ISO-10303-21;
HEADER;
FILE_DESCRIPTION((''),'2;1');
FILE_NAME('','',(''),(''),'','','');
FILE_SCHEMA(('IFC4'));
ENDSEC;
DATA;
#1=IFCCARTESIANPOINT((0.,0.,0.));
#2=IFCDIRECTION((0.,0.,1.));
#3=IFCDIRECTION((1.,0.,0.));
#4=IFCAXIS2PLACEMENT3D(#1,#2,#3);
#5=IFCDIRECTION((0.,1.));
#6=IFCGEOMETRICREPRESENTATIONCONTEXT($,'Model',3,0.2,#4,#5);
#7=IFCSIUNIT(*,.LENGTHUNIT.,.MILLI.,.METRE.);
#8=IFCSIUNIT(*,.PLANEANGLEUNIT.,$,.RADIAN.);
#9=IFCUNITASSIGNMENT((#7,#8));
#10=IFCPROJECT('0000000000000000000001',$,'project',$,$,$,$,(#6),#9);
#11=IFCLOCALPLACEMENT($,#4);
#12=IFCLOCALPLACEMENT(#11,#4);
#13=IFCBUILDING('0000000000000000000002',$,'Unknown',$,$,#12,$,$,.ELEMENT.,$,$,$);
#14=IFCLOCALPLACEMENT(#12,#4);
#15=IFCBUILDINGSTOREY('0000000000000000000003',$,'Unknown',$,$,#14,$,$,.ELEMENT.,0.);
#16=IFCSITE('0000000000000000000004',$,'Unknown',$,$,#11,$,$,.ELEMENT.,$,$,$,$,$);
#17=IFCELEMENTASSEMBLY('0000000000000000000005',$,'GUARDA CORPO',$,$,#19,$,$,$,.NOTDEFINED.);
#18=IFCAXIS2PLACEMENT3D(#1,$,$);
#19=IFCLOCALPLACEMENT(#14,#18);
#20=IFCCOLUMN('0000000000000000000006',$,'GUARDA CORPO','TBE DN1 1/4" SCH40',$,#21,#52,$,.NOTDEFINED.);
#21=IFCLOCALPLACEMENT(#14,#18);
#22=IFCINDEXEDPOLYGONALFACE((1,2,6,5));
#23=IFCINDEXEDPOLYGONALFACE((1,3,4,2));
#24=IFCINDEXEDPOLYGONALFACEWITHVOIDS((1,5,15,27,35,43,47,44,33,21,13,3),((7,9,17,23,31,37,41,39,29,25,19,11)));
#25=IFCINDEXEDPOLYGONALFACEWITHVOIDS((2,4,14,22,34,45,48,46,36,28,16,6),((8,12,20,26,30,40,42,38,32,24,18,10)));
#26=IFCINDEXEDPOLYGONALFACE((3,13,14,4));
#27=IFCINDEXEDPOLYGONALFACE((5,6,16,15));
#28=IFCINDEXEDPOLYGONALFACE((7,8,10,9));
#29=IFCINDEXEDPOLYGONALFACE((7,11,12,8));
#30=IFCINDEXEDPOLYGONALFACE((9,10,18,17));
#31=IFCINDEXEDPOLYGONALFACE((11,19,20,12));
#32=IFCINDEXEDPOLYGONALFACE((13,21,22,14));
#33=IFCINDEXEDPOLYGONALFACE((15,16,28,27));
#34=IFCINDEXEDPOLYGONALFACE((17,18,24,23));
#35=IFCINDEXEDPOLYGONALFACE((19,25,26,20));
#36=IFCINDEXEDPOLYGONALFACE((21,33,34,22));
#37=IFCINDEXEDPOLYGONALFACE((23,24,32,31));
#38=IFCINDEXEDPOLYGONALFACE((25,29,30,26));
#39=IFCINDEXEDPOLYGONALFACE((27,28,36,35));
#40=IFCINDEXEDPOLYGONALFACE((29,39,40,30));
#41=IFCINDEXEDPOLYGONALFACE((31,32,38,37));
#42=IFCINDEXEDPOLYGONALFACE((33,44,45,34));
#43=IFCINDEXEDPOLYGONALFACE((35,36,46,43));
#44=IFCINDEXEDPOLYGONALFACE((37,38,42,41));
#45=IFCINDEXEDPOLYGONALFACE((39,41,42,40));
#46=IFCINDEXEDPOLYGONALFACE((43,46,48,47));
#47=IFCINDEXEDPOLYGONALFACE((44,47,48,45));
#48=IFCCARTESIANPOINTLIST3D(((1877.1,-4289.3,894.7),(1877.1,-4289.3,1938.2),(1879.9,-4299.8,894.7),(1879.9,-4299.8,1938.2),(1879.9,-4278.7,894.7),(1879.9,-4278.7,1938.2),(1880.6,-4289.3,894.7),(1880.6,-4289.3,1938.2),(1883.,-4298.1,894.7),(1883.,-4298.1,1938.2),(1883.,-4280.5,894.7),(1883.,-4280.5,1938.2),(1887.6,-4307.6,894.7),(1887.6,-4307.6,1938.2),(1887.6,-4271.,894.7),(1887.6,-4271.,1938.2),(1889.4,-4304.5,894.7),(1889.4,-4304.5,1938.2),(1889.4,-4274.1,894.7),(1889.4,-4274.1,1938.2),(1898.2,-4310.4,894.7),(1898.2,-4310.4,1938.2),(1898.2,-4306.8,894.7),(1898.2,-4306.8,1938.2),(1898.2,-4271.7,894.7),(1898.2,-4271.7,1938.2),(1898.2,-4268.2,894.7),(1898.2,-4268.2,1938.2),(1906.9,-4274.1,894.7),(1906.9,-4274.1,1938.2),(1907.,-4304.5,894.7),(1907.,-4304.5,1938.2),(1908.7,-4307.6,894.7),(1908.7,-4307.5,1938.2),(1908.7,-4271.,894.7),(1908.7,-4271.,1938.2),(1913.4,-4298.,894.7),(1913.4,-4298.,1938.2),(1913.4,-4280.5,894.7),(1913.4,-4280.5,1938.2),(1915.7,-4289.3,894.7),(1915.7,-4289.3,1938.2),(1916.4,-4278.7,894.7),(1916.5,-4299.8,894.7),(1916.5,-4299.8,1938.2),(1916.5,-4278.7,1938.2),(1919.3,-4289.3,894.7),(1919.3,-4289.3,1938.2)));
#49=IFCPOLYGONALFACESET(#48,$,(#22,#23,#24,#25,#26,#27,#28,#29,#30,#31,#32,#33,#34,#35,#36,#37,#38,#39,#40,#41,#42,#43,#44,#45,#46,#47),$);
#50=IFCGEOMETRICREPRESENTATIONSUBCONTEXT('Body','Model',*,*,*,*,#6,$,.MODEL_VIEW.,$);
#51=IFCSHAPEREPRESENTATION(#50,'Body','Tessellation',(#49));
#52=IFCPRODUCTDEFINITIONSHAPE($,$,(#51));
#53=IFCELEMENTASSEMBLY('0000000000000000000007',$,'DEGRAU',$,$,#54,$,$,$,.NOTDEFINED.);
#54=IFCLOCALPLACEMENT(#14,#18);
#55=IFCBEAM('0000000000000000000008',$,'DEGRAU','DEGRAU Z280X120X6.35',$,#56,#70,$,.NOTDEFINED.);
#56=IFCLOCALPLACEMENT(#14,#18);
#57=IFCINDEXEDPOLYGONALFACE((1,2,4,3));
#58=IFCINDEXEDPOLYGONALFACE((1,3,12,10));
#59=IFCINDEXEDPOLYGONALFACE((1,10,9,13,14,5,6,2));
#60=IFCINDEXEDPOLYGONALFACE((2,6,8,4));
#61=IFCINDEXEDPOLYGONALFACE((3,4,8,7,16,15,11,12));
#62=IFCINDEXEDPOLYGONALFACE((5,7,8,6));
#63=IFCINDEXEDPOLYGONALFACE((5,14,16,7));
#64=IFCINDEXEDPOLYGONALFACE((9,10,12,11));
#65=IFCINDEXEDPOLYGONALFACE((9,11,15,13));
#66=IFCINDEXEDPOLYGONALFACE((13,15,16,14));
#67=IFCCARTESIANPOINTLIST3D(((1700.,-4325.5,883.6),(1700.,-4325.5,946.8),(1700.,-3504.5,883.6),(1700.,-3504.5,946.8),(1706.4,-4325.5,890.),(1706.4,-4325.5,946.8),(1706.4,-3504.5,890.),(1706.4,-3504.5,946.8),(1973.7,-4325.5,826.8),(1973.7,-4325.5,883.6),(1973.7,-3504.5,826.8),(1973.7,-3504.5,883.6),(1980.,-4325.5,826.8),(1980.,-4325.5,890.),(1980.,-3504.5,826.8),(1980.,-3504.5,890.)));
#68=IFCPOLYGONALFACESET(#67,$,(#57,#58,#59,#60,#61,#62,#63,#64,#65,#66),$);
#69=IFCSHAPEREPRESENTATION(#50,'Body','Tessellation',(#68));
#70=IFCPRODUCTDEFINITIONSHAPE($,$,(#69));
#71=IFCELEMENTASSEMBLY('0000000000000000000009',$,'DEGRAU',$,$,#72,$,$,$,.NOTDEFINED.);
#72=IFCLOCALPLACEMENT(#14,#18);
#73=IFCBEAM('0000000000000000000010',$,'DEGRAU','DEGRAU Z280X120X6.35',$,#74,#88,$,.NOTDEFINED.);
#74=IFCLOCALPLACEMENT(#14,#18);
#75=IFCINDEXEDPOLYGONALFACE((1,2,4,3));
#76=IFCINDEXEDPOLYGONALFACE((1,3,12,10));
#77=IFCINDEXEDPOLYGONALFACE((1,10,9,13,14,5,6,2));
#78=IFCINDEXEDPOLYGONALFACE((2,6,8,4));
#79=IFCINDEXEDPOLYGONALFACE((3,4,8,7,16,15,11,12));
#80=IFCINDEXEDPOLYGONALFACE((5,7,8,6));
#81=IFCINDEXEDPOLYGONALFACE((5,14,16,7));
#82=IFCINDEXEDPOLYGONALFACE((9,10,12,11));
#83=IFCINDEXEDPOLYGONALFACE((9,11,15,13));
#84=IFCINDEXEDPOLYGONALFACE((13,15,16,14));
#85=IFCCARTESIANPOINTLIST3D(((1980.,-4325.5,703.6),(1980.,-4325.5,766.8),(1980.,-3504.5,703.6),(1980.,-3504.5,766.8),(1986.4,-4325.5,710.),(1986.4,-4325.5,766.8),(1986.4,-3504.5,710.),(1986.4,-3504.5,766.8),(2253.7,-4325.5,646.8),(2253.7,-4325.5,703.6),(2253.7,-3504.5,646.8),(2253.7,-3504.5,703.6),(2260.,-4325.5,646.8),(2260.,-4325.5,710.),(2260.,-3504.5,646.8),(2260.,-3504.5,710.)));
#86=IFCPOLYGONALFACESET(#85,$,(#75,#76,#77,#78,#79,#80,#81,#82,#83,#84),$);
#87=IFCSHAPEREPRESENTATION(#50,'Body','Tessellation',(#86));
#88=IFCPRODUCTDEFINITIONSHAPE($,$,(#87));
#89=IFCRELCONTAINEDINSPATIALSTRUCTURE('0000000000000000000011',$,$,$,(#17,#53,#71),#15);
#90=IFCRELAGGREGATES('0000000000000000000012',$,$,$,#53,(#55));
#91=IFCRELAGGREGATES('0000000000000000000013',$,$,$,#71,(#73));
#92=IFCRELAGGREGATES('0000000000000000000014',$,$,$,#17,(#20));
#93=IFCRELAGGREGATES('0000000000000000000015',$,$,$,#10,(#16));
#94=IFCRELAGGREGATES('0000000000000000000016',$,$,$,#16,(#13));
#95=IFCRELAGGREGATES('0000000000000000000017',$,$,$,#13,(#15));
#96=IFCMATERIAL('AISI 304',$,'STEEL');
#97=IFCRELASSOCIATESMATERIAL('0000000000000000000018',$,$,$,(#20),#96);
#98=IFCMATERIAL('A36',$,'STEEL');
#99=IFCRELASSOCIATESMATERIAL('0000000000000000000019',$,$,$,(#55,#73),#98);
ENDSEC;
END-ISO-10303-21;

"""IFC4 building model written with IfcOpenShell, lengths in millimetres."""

from ifc_helpers import new_model, si_unit, direction, frame, origin_with_axes, place, context, subcontext, project, spatial, line, indexed_curve, outline, extrude, material, element, aggregate, save


model = new_model("IFC4")

# Units and contexts
model_context = context("Model", 3, precision=0.2, world=origin_with_axes(), true_north=direction((0.0, 1.0)))
body_context = subcontext(model_context, "Body", "Model", "MODEL_VIEW")
ifc_project = project(units=[si_unit("LENGTHUNIT", "METRE", prefix="MILLI"), si_unit("PLANEANGLEUNIT", "RADIAN")], contexts=[model_context])

# Site, building, storey
site_placement = place(None, origin_with_axes())
site = spatial("IfcSite", under=ifc_project, at=site_placement, Name="Unknown", CompositionType="ELEMENT")
building_placement = place(site_placement, origin_with_axes())
building = spatial("IfcBuilding", under=site, at=building_placement, Name="Unknown", CompositionType="ELEMENT")
storey_placement = place(building_placement, origin_with_axes())
storey = spatial("IfcBuildingStorey", under=building, at=storey_placement, Name="Unknown", CompositionType="ELEMENT", Elevation=0.0)

# Element assembly, column
assembly_1_placement = place(storey_placement, frame((833.2, -4289.3, 1615.0), z_axis=(-0.000512, 1.0, -0.000003), x_axis=(0.000003, 0.000003, 1.0)))
assembly_1 = element("IfcElementAssembly", 1, at=assembly_1_placement, inside=storey, Name="GUARDA CORPO", PredefinedType="NOTDEFINED")
ifc_material_1 = material(Name="AISI 304", Category="STEEL")
column_placement = place(assembly_1_placement, frame((-720.3, 1065.0, -0.5), z_axis=(0.0, 0.0, 1.0), x_axis=(1.0, 0.0, 0.0)))
column = element("IfcColumn", 2, at=column_placement, material=ifc_material_1, Name="GUARDA CORPO", Description="TBE DN1 1/4\" SCH40", PredefinedType="NOTDEFINED", context=body_context, shape_type="SolidModel", body=[
    extrude(outline(indexed_curve([(21.1, 0.0), (18.3, 10.6), (10.6, 18.3), (0.0, 21.1), (-10.6, 18.3), (-18.3, 10.6), (-21.1, 0.0), (-18.3, -10.6), (-10.6, -18.3), (0.0, -21.1), (10.6, -18.3), (18.3, -10.6)], segments=[line(1, 2, 3, 4, 5, 6, 7, 8, 9, 10, 11, 12, 1)]), holes=[indexed_curve([(17.5, 0.0), (15.2, -8.8), (8.8, -15.2), (0.0, -17.5), (-8.8, -15.2), (-15.2, -8.8), (-17.5, 0.0), (-15.2, 8.8), (-8.8, 15.2), (0.0, 17.5), (8.8, 15.2), (15.2, 8.8)], segments=[line(1, 2, 3, 4, 5, 6, 7, 8, 9, 10, 11, 12, 1)])]), frame((0.0, 0.0, 0.0), z_axis=(-1.0, 0.0, 0.0), x_axis=(0.0, 0.0, 1.0)), (0.0, 0.0, -1.0), 1043.5),
])

# Element assemblies, beams
assembly_2_placement = place(storey_placement, frame((1840.0, -3504.5, 886.8), z_axis=(0.0, 0.0, -1.0), x_axis=(0.0, -1.0, 0.0)))
assembly_2 = element("IfcElementAssembly", 3, at=assembly_2_placement, inside=storey, Name="DEGRAU", PredefinedType="NOTDEFINED")
ifc_material_2 = material(Name="A36", Category="STEEL")
beam_1_placement = place(assembly_2_placement, origin_with_axes())
beam_1 = element("IfcBeam", 4, at=beam_1_placement, material=ifc_material_2, Name="DEGRAU", Description="DEGRAU Z280X120X6.35", PredefinedType="NOTDEFINED", context=body_context, shape_type="SolidModel", body=[
    extrude(outline(indexed_curve([(-3.2, -140.0), (60.0, -140.0), (60.0, -133.7), (3.2, -133.7), (3.2, 140.0), (-60.0, 140.0), (-60.0, 133.7), (-3.2, 133.7)], segments=[line(1, 2, 3, 4, 5, 6, 7, 8, 1)])), frame((0.0, 0.0, 0.0), z_axis=(-1.0, 0.0, 0.0), x_axis=(0.0, 0.0, 1.0)), (0.0, 0.0, -1.0), 821.0),
])
assembly_3_placement = place(storey_placement, frame((2120.0, -3504.5, 706.8), z_axis=(0.0, 0.0, -1.0), x_axis=(0.0, -1.0, 0.0)))
assembly_3 = element("IfcElementAssembly", 5, at=assembly_3_placement, inside=storey, Name="DEGRAU", PredefinedType="NOTDEFINED")
beam_2_placement = place(assembly_3_placement, origin_with_axes())
beam_2 = element("IfcBeam", 6, at=beam_2_placement, material=ifc_material_2, Name="DEGRAU", Description="DEGRAU Z280X120X6.35", PredefinedType="NOTDEFINED", context=body_context, shape_type="SolidModel", body=[
    extrude(outline(indexed_curve([(-3.2, -140.0), (60.0, -140.0), (60.0, -133.7), (3.2, -133.7), (3.2, 140.0), (-60.0, 140.0), (-60.0, 133.7), (-3.2, 133.7)], segments=[line(1, 2, 3, 4, 5, 6, 7, 8, 1)])), frame((0.0, 0.0, 0.0), z_axis=(-1.0, 0.0, 0.0), x_axis=(0.0, 0.0, 1.0)), (0.0, 0.0, -1.0), 821.0),
])

aggregate(assembly_2, [beam_1])
aggregate(assembly_3, [beam_2])

aggregate(assembly_1, [column])

save(model, "model.ifc")
